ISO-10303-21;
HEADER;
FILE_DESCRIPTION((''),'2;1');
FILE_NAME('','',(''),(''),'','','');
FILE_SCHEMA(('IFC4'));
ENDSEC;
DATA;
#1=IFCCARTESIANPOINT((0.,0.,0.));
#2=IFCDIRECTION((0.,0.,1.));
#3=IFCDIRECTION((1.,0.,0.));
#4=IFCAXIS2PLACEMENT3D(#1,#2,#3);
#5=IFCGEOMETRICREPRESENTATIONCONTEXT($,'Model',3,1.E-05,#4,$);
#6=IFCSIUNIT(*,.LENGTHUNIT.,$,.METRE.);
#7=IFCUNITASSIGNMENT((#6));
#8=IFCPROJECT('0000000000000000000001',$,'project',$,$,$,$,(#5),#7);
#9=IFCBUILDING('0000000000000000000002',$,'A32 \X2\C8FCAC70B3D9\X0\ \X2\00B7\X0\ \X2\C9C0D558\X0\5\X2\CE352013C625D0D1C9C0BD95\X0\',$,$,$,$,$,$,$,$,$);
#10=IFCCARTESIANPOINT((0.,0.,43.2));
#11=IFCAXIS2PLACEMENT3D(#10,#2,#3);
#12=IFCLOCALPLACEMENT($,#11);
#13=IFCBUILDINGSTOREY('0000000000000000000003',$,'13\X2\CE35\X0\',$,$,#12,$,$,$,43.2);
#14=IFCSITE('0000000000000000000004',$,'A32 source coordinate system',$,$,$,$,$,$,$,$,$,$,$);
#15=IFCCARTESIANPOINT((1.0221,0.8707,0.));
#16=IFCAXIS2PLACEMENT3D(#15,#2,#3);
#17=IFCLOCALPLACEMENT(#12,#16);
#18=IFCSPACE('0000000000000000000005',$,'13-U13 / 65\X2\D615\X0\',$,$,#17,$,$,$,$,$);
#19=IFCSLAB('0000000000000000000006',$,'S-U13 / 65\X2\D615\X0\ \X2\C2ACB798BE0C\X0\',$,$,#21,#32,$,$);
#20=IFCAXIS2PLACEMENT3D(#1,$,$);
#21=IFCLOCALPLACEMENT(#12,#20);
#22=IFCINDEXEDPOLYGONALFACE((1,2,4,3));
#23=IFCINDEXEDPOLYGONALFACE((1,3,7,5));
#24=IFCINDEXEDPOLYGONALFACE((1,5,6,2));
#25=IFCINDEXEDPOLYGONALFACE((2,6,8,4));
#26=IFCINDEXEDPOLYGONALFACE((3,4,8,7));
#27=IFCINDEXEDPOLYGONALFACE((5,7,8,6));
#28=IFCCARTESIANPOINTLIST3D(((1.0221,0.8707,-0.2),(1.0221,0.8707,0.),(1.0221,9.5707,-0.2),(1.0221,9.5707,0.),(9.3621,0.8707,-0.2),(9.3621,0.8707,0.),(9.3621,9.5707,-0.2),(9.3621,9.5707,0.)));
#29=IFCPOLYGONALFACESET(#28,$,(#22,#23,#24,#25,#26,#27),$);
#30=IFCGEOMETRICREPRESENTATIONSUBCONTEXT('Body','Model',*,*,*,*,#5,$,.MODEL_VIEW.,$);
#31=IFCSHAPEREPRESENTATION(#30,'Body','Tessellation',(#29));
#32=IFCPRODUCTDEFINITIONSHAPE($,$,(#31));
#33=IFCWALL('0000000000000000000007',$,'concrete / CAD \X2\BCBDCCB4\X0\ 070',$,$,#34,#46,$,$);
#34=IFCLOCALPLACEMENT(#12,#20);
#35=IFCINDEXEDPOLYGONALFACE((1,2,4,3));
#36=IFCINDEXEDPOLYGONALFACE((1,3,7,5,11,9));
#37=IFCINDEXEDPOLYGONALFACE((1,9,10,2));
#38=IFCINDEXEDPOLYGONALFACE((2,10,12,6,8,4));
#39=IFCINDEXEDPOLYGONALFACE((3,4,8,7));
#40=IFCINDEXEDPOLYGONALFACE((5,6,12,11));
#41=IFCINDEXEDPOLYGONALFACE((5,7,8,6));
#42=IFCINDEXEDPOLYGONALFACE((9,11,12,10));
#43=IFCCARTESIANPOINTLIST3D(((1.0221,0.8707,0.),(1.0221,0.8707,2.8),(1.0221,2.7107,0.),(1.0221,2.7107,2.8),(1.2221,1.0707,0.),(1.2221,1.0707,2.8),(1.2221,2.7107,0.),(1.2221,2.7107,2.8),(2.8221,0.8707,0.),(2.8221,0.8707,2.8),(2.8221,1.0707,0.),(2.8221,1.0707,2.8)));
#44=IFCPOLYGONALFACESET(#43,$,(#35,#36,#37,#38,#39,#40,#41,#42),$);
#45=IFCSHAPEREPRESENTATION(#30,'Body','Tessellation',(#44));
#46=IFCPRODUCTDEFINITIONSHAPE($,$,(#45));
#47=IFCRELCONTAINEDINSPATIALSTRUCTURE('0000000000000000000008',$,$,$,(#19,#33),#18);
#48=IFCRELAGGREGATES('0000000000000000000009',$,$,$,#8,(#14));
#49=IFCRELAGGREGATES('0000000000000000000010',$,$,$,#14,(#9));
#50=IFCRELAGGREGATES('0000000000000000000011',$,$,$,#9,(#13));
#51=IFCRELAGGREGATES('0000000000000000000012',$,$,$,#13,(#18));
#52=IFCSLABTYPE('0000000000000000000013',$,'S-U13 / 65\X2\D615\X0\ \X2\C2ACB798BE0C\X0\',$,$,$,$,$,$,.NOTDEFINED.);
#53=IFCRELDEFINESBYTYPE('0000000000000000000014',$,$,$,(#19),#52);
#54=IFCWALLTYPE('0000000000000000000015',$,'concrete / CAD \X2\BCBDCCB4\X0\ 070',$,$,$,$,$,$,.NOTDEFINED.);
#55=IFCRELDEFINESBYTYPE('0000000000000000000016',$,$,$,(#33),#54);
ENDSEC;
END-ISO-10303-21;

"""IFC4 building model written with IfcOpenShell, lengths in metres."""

from ifc_helpers import new_model, si_unit, frame, origin, origin_with_axes, place, context, subcontext, project, spatial, polyline, outline, extrude, source, transform, mapped, type_object, type_shapes, element, save


model = new_model("IFC4")

# Units and contexts
model_context = context("Model", 3, precision=1e-05, world=origin_with_axes())
body_context = subcontext(model_context, "Body", "Model", "MODEL_VIEW")
ifc_project = project(units=[si_unit("LENGTHUNIT", "METRE")], contexts=[model_context])

# Site, building, storey, space
storey_placement = place(None, frame((0.0, 0.0, 43.2), z_axis=(0.0, 0.0, 1.0), x_axis=(1.0, 0.0, 0.0)))
space_placement = place(storey_placement, frame((1.0221, 0.8707, 0.0), z_axis=(0.0, 0.0, 1.0), x_axis=(1.0, 0.0, 0.0)))
site = spatial("IfcSite", under=ifc_project, Name="A32 source coordinate system")
building = spatial("IfcBuilding", under=site, Name="A32 주거동 · 지하5층–옥탑지붕")
storey = spatial("IfcBuildingStorey", under=building, at=storey_placement, Name="13층", Elevation=43.2)
space = spatial("IfcSpace", under=storey, at=space_placement, Name="13-U13 / 65형")

# Slab
slab_type = type_object("IfcSlabType", Name="S-U13 / 65형 슬래브", PredefinedType="NOTDEFINED")
shared_shape_1 = source(origin(), body_context, "Body", "SweptSolid", [
    extrude(outline(polyline([(0.0, 0.0), (0.0, 8.7), (8.34, 8.7), (8.34, 0.0), (0.0, 0.0)])), frame((0.0, 0.0, -0.2)), (0.0, 0.0, 1.0), 0.2),
])
type_shapes(slab_type, [shared_shape_1])
slab_placement = place(space_placement, origin_with_axes())
element("IfcSlab", 1, at=slab_placement, inside=space, type_object=slab_type, Name="S-U13 / 65형 슬래브", context=body_context, shape_type="MappedRepresentation", body=[
    mapped(shared_shape_1, transform((0.0, 0.0, 0.0), scale=1.0)),
])

# Wall
wall_type_1 = type_object("IfcWallType", Name="concrete / CAD 벽체 070", PredefinedType="NOTDEFINED")
shared_shape_2 = source(origin(), body_context, "Body", "SweptSolid", [
    extrude(outline(polyline([(0.2, 1.84), (0.2, 0.2), (1.8, 0.2), (1.8, 0.0), (0.0, 0.0), (0.0, 1.84), (0.2, 1.84)])), origin(), (0.0, 0.0, 1.0), 2.8),
])
type_shapes(wall_type_1, [shared_shape_2])
wall_1_placement = place(space_placement, origin_with_axes())
element("IfcWall", 2, at=wall_1_placement, inside=space, type_object=wall_type_1, Name="concrete / CAD 벽체 070", context=body_context, shape_type="MappedRepresentation", body=[
    mapped(shared_shape_2, transform((0.0, 0.0, 0.0), scale=1.0)),
])

save(model, "model.ifc")
